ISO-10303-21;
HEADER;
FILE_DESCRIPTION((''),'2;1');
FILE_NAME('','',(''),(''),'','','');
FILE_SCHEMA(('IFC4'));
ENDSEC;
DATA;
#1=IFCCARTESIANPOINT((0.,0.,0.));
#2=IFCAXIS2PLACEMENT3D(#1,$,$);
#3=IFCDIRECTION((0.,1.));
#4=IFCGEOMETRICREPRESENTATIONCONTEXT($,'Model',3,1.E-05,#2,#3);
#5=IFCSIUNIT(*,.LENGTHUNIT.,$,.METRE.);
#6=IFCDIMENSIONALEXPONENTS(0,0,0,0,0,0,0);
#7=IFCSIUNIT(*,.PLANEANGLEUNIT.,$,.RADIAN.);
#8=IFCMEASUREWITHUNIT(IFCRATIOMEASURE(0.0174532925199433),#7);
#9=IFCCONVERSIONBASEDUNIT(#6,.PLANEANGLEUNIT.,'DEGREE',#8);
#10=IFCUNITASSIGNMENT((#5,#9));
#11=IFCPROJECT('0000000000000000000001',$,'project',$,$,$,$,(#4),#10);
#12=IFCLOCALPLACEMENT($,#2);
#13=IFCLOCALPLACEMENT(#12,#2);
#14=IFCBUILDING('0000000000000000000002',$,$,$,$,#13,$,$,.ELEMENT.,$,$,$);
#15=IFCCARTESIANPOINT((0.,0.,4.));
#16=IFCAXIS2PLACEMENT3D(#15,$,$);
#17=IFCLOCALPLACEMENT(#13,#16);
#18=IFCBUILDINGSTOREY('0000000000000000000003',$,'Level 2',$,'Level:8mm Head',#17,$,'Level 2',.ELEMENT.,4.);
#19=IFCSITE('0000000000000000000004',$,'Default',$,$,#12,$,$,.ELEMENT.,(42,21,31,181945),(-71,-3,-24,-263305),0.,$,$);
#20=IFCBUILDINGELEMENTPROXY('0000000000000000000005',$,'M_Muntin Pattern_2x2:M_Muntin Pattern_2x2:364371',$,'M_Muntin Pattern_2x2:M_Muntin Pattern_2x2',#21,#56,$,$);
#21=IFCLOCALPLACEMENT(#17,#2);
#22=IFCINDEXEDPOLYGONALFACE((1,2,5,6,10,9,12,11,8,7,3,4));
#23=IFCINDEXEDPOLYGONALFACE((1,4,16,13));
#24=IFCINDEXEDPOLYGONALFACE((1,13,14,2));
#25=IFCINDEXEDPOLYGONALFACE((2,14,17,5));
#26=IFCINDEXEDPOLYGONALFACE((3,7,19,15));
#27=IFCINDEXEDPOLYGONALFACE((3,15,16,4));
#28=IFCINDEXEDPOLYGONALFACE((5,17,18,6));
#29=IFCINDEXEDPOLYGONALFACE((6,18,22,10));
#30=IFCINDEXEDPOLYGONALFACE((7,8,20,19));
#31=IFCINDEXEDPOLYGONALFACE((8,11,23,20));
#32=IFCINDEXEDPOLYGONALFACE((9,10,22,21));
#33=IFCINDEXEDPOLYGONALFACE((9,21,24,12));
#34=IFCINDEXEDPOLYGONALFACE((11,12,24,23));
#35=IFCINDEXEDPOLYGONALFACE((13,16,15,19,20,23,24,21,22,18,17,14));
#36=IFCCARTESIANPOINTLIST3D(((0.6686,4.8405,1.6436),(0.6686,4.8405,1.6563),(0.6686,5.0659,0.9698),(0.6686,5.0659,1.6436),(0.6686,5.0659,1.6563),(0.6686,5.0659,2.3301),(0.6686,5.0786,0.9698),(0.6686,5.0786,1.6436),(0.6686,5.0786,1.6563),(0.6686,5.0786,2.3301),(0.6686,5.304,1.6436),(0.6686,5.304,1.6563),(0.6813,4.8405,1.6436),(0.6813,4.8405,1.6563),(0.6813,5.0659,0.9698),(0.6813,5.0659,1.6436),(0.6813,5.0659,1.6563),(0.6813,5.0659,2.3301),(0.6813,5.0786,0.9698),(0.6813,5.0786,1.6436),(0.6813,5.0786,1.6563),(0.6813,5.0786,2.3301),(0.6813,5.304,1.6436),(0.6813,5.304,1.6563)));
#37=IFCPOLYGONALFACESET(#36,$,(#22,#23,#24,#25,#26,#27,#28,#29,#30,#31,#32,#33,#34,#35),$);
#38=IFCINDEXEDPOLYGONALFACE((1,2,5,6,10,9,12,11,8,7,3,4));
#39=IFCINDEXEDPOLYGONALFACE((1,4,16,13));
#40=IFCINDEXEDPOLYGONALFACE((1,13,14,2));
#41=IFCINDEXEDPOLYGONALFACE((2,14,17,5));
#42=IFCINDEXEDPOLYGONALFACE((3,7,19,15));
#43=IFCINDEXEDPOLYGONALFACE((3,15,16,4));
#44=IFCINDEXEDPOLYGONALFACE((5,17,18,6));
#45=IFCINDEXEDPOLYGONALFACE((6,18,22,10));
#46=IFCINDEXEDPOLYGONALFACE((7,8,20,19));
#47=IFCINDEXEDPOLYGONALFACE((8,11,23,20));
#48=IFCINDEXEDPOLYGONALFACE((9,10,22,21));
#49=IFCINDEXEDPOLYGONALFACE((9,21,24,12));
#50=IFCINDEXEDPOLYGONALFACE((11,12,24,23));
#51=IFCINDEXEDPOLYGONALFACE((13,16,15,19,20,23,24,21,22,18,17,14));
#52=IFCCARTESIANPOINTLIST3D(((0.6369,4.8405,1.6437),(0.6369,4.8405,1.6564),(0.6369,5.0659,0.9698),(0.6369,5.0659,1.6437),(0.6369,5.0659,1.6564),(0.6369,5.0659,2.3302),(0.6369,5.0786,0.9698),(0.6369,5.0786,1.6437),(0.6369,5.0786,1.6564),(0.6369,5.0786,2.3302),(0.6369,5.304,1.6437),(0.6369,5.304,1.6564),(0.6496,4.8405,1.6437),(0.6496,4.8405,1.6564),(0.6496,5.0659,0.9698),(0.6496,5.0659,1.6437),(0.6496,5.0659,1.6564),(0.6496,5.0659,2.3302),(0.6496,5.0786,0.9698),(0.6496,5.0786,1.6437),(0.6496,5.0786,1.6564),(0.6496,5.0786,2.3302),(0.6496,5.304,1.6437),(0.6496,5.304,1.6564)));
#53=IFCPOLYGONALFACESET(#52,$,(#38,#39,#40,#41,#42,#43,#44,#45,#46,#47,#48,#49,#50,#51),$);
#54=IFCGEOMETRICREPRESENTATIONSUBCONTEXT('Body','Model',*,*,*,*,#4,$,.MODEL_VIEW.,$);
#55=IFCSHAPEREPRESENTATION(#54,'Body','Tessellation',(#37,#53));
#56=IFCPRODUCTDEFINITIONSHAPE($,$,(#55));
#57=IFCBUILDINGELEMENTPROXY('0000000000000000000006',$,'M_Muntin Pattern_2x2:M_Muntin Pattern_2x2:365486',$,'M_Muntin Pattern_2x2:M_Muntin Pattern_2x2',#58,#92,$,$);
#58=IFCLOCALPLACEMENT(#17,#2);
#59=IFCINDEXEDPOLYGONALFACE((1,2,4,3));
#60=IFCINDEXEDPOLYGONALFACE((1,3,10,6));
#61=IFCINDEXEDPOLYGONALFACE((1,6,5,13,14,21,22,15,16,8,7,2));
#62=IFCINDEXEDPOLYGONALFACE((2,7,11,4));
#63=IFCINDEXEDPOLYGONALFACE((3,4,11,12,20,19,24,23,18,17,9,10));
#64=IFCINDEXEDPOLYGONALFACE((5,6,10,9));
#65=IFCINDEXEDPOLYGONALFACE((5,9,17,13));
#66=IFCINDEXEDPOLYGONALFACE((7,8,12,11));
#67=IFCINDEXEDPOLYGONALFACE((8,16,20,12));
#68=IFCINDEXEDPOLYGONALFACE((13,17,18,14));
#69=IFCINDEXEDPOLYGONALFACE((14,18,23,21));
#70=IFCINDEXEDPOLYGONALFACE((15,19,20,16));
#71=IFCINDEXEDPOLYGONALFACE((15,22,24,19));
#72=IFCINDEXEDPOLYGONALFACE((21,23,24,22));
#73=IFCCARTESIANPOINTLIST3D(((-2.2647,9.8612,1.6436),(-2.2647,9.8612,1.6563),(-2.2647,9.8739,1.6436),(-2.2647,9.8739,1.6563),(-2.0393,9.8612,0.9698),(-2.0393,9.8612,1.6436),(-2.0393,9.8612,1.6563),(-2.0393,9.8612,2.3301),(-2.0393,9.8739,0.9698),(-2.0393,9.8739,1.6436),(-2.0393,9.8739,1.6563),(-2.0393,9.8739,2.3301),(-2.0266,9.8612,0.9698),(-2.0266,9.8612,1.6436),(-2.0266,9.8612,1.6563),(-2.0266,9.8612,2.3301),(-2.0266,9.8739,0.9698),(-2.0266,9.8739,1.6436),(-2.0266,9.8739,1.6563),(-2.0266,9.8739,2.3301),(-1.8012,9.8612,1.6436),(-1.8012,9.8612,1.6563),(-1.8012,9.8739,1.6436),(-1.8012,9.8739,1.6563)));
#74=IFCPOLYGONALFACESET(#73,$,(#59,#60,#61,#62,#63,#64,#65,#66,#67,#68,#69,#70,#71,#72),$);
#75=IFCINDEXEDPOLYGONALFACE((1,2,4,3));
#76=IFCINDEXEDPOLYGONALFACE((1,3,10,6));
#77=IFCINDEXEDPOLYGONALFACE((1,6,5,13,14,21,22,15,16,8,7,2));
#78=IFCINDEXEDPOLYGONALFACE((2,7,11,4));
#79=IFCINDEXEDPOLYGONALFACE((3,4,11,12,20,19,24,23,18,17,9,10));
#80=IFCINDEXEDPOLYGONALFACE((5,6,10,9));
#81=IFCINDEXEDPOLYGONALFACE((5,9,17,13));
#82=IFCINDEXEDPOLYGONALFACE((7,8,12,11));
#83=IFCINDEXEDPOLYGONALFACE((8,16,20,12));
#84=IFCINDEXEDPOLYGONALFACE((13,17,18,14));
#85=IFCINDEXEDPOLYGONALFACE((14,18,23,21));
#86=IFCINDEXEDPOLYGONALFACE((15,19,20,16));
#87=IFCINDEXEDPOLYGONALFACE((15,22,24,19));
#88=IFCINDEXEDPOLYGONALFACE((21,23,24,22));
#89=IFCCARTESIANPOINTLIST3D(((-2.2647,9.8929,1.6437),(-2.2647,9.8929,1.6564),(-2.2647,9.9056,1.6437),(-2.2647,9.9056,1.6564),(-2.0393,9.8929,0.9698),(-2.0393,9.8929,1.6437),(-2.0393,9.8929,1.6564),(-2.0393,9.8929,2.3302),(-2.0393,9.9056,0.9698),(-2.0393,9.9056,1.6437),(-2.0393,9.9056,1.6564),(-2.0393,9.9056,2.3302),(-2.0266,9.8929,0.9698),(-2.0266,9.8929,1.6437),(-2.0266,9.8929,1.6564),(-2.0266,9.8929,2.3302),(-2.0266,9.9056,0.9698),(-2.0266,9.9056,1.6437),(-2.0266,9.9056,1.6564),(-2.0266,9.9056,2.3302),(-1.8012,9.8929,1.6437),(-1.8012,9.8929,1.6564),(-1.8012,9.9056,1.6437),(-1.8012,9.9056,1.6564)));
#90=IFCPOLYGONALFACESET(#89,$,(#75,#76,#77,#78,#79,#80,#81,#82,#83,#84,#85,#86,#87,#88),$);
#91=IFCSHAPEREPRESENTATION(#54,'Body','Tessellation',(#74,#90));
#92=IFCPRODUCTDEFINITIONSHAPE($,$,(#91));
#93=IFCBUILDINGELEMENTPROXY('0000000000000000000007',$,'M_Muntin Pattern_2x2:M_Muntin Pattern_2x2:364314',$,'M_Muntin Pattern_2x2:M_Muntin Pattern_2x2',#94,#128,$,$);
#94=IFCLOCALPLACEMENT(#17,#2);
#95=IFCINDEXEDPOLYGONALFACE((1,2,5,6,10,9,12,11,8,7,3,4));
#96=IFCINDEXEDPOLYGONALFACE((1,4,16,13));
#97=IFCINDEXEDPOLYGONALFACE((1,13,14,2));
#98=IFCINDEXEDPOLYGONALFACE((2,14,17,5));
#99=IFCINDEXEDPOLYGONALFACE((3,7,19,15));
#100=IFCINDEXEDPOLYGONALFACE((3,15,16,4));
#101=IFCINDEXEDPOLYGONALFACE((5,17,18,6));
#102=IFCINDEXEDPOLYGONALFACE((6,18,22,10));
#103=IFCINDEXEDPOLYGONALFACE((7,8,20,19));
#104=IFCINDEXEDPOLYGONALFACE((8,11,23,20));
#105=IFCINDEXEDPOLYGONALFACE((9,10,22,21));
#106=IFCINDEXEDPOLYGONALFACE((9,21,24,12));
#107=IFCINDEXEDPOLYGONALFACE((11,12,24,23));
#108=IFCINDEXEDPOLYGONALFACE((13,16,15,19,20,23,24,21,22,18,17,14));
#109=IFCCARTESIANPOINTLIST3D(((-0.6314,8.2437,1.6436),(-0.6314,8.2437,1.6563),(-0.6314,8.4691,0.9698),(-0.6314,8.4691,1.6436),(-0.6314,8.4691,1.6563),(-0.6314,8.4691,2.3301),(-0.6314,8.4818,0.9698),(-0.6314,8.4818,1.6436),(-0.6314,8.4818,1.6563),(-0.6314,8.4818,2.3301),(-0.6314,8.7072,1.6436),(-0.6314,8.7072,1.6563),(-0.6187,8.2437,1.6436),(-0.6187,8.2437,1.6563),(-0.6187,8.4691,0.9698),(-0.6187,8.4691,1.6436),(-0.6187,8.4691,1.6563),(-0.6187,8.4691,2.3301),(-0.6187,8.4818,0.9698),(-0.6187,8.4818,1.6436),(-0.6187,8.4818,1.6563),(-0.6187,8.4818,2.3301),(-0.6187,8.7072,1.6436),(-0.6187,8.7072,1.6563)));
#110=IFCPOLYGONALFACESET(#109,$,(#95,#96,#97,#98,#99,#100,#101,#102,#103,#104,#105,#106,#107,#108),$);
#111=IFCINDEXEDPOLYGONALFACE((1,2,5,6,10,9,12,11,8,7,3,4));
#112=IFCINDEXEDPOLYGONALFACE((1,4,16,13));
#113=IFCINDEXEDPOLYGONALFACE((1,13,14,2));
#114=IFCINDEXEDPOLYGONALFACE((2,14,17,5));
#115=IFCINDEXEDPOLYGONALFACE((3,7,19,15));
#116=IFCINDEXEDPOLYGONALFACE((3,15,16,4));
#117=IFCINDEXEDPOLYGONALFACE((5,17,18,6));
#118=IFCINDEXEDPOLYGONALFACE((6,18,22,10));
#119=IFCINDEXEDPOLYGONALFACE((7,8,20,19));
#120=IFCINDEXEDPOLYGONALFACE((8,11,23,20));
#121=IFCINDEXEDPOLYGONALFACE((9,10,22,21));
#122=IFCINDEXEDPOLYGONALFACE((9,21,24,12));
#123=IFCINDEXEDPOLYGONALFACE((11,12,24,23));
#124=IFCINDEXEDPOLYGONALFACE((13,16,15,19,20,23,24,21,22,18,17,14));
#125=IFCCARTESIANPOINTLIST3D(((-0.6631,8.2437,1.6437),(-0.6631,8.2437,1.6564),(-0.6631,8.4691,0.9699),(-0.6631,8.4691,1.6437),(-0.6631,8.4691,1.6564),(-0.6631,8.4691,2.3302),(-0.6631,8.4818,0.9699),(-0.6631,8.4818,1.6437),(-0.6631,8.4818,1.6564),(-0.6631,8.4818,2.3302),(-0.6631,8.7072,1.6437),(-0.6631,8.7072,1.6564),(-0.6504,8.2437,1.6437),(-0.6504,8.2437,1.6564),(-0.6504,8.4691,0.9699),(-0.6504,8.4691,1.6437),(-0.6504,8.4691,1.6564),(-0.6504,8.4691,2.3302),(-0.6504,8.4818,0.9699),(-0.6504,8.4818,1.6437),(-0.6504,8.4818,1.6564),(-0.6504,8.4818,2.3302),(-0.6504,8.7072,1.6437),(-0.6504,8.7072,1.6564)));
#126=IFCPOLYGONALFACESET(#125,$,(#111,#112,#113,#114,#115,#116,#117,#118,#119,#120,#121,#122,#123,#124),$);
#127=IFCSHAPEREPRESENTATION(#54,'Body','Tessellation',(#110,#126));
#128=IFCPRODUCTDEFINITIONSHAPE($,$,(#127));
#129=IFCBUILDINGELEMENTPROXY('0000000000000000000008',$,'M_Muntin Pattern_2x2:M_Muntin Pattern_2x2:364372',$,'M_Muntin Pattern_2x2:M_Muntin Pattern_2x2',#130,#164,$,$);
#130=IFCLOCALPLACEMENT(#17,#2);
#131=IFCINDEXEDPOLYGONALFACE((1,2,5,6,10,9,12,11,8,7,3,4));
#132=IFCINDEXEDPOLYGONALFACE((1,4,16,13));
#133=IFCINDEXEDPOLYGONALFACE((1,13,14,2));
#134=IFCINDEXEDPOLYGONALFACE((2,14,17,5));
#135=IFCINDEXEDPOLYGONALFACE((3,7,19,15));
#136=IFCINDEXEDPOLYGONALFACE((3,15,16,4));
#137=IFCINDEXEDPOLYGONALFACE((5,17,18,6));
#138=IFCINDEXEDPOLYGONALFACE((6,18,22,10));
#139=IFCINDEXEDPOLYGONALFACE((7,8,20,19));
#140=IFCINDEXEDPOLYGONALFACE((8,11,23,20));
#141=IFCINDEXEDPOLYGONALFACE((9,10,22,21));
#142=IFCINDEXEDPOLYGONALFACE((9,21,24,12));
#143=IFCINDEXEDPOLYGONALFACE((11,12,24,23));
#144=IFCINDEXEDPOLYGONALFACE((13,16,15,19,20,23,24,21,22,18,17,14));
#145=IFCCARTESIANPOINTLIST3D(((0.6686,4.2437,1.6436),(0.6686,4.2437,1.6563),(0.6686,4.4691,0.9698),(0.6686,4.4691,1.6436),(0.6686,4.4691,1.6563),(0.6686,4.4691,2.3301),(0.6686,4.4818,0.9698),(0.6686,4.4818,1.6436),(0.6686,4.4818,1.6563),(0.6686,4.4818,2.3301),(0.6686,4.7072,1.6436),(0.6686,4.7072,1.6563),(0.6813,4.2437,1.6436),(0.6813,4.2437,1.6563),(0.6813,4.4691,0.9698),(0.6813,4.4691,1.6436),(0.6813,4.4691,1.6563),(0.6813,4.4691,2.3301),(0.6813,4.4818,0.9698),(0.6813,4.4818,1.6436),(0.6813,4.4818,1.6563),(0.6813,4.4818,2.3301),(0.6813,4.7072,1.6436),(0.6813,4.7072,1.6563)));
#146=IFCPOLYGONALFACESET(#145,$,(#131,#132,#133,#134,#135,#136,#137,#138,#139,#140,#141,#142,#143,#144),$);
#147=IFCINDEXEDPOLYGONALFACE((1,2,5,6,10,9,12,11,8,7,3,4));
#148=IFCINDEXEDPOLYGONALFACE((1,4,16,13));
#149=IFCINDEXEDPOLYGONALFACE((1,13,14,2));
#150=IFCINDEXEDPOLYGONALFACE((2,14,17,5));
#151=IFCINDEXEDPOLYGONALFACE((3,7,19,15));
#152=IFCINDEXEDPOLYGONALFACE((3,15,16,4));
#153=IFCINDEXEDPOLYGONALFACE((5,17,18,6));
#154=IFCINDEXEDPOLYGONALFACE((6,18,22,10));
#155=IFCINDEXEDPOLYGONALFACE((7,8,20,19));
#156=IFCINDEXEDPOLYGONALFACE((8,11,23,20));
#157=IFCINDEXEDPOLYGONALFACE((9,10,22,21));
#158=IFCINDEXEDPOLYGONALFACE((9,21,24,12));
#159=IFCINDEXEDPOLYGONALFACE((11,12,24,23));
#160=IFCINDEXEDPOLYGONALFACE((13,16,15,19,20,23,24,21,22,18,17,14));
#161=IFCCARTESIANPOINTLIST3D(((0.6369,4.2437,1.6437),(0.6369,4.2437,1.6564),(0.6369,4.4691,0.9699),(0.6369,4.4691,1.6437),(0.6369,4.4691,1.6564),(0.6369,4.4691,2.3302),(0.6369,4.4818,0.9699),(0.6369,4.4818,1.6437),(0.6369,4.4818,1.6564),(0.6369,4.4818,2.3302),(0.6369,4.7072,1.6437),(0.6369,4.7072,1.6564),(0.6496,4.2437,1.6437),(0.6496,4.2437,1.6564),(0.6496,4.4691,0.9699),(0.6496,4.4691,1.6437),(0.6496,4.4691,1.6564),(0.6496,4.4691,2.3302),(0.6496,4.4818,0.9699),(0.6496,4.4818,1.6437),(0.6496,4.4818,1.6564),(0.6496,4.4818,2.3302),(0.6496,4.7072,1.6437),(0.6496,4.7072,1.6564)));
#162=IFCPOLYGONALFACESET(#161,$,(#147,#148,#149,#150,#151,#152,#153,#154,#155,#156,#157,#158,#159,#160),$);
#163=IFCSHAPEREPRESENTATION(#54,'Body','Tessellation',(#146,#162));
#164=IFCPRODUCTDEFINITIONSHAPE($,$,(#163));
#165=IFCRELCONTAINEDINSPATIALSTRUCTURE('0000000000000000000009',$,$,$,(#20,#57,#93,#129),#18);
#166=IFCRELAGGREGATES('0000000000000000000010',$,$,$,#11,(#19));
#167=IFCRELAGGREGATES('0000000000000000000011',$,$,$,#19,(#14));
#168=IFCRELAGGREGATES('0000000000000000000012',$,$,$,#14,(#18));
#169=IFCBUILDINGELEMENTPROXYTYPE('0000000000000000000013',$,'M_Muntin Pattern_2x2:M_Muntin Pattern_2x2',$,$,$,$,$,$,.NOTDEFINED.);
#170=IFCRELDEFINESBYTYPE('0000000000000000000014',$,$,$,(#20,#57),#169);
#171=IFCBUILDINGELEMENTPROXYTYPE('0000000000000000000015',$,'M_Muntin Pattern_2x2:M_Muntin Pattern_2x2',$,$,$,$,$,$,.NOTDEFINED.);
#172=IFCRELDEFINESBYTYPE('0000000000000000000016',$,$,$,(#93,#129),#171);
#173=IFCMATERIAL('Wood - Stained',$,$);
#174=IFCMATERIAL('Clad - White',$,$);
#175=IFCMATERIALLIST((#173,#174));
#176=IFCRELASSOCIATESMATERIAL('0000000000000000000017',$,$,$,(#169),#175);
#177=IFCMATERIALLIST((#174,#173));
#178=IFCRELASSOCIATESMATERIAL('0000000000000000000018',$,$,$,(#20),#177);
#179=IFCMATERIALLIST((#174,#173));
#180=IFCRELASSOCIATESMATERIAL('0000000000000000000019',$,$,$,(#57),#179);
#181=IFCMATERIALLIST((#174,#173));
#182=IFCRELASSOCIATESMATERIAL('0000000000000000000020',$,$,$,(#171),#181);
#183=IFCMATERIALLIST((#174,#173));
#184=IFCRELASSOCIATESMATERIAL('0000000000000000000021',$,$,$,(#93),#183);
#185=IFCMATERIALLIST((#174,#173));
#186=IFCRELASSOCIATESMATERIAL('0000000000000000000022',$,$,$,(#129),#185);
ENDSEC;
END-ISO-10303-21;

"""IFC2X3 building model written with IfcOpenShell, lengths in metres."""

from ifc_helpers import new_model, entity, si_unit, converted_unit, direction, frame, origin, place, context, subcontext, project, spatial, polyline, outline, extrude, source, transform, mapped, material, material_list, type_object, type_shapes, element, save


model = new_model("IFC2X3")

# Units and contexts
model_context = context("Model", 3, precision=1e-05, world=origin(), true_north=direction((0.0, 1.0)))
body_context = subcontext(model_context, "Body", "Model", "MODEL_VIEW")
ifc_project = project(units=[si_unit("LENGTHUNIT", "METRE"), converted_unit("PLANEANGLEUNIT", "DEGREE", entity("IfcRatioMeasure", 0.0174532925199433), si_unit("PLANEANGLEUNIT", "RADIAN"), dimensions=[0, 0, 0, 0, 0, 0, 0])], contexts=[model_context])

# Site, building, storey
site_placement = place(None, origin())
site = spatial("IfcSite", under=ifc_project, at=site_placement, Name="Default", CompositionType="ELEMENT", RefLatitude=(42, 21, 31, 181945), RefLongitude=(-71, -3, -24, -263305), RefElevation=0.0)
building_placement = place(site_placement, origin())
building = spatial("IfcBuilding", under=site, at=building_placement, CompositionType="ELEMENT")
storey_placement = place(building_placement, frame((0.0, 0.0, 4.0)))
storey = spatial("IfcBuildingStorey", under=building, at=storey_placement, Name="Level 2", ObjectType="Level:8mm Head", LongName="Level 2", CompositionType="ELEMENT", Elevation=4.0)

# Building element proxies
ifc_material_1 = material(Name="Clad - White")
ifc_material_2 = material(Name="Wood - Stained")
ifc_material_list_1 = material_list([ifc_material_2, ifc_material_1])
building_element_proxy_type_1 = type_object("IfcBuildingElementProxyType", Name="M_Muntin Pattern_2x2:M_Muntin Pattern_2x2", PredefinedType="NOTDEFINED", material=ifc_material_list_1)
shared_shape_1 = source(origin(), body_context, "Body", "SweptSolid", [
    extrude(outline(polyline([(0.0064, -0.0064), (0.6801, -0.0064), (0.6801, 0.0063), (0.0064, 0.0063), (0.0064, 0.2317), (-0.0063, 0.2317), (-0.0063, 0.0063), (-0.6802, 0.0063), (-0.6802, -0.0064), (-0.0063, -0.0064), (-0.0063, -0.2317), (0.0064, -0.2317), (0.0064, -0.0064)])), frame((0.0, 0.0095, 0.6801), z_axis=(0.0, 1.0, 0.0), x_axis=(0.0, 0.0, 1.0)), (0.0, 0.0, 1.0), 0.0127),
    extrude(outline(polyline([(0.0064, -0.0064), (0.6802, -0.0064), (0.6802, 0.0063), (0.0064, 0.0063), (0.0064, 0.2317), (-0.0063, 0.2317), (-0.0063, 0.0063), (-0.6802, 0.0063), (-0.6802, -0.0064), (-0.0063, -0.0064), (-0.0063, -0.2317), (0.0064, -0.2317), (0.0064, -0.0064)])), frame((0.0, -0.0222, 0.6802), z_axis=(0.0, 1.0, 0.0), x_axis=(0.0, 0.0, 1.0)), (0.0, 0.0, 1.0), 0.0127),
])
type_shapes(building_element_proxy_type_1, [shared_shape_1])
ifc_material_list_2 = material_list([ifc_material_1, ifc_material_2])
proxy_1_placement = place(storey_placement, frame((0.6591, 5.0723, 0.9698), z_axis=(0.0, 0.0, 1.0), x_axis=(0.0, -1.0, 0.0)))
element("IfcBuildingElementProxy", 1, at=proxy_1_placement, inside=storey, type_object=building_element_proxy_type_1, material=ifc_material_list_2, Name="M_Muntin Pattern_2x2:M_Muntin Pattern_2x2:364371", ObjectType="M_Muntin Pattern_2x2:M_Muntin Pattern_2x2", context=body_context, shape_type="MappedRepresentation", body=[
    mapped(shared_shape_1, transform((0.0, 0.0, 0.0), scale=1.0)),
])
ifc_material_list_3 = material_list([ifc_material_1, ifc_material_2])
proxy_2_placement = place(storey_placement, frame((-2.033, 9.8834, 0.9698), z_axis=(0.0, 0.0, 1.0), x_axis=(-1.0, 0.0, 0.0)))
element("IfcBuildingElementProxy", 2, at=proxy_2_placement, inside=storey, type_object=building_element_proxy_type_1, material=ifc_material_list_3, Name="M_Muntin Pattern_2x2:M_Muntin Pattern_2x2:365486", ObjectType="M_Muntin Pattern_2x2:M_Muntin Pattern_2x2", context=body_context, shape_type="MappedRepresentation", body=[
    mapped(shared_shape_1, transform((0.0, 0.0, 0.0), scale=1.0)),
])
ifc_material_list_4 = material_list([ifc_material_1, ifc_material_2])
ifc_material_list_5 = material_list([ifc_material_1, ifc_material_2])
building_element_proxy_type_2 = type_object("IfcBuildingElementProxyType", Name="M_Muntin Pattern_2x2:M_Muntin Pattern_2x2", PredefinedType="NOTDEFINED", material=ifc_material_list_5)
shared_shape_2 = source(origin(), body_context, "Body", "SweptSolid", [
    extrude(outline(polyline([(0.0064, -0.0064), (0.6801, -0.0064), (0.6801, 0.0063), (0.0064, 0.0063), (0.0064, 0.2317), (-0.0063, 0.2317), (-0.0063, 0.0063), (-0.6802, 0.0063), (-0.6802, -0.0064), (-0.0063, -0.0064), (-0.0063, -0.2317), (0.0064, -0.2317), (0.0064, -0.0064)])), frame((0.0, -0.0222, 0.6801), z_axis=(0.0, 1.0, 0.0), x_axis=(0.0, 0.0, 1.0)), (0.0, 0.0, 1.0), 0.0127),
    extrude(outline(polyline([(0.0064, -0.0064), (0.6802, -0.0064), (0.6802, 0.0063), (0.0064, 0.0063), (0.0064, 0.2317), (-0.0063, 0.2317), (-0.0063, 0.0063), (-0.6802, 0.0063), (-0.6802, -0.0064), (-0.0063, -0.0064), (-0.0063, -0.2317), (0.0064, -0.2317), (0.0064, -0.0064)])), frame((0.0, 0.0095, 0.6802), z_axis=(0.0, 1.0, 0.0), x_axis=(0.0, 0.0, 1.0)), (0.0, 0.0, 1.0), 0.0127),
])
type_shapes(building_element_proxy_type_2, [shared_shape_2])
proxy_3_placement = place(storey_placement, frame((-0.6409, 8.4754, 0.9699), z_axis=(0.0, 0.0, 1.0), x_axis=(0.0, 1.0, 0.0)))
element("IfcBuildingElementProxy", 3, at=proxy_3_placement, inside=storey, type_object=building_element_proxy_type_2, material=ifc_material_list_4, Name="M_Muntin Pattern_2x2:M_Muntin Pattern_2x2:364314", ObjectType="M_Muntin Pattern_2x2:M_Muntin Pattern_2x2", context=body_context, shape_type="MappedRepresentation", body=[
    mapped(shared_shape_2, transform((0.0, 0.0, 0.0), scale=1.0)),
])
ifc_material_list_6 = material_list([ifc_material_1, ifc_material_2])
proxy_4_placement = place(storey_placement, frame((0.6591, 4.4754, 0.9699), z_axis=(0.0, 0.0, 1.0), x_axis=(0.0, 1.0, 0.0)))
element("IfcBuildingElementProxy", 4, at=proxy_4_placement, inside=storey, type_object=building_element_proxy_type_2, material=ifc_material_list_6, Name="M_Muntin Pattern_2x2:M_Muntin Pattern_2x2:364372", ObjectType="M_Muntin Pattern_2x2:M_Muntin Pattern_2x2", context=body_context, shape_type="MappedRepresentation", body=[
    mapped(shared_shape_2, transform((0.0, 0.0, 0.0), scale=1.0)),
])

save(model, "model.ifc")
